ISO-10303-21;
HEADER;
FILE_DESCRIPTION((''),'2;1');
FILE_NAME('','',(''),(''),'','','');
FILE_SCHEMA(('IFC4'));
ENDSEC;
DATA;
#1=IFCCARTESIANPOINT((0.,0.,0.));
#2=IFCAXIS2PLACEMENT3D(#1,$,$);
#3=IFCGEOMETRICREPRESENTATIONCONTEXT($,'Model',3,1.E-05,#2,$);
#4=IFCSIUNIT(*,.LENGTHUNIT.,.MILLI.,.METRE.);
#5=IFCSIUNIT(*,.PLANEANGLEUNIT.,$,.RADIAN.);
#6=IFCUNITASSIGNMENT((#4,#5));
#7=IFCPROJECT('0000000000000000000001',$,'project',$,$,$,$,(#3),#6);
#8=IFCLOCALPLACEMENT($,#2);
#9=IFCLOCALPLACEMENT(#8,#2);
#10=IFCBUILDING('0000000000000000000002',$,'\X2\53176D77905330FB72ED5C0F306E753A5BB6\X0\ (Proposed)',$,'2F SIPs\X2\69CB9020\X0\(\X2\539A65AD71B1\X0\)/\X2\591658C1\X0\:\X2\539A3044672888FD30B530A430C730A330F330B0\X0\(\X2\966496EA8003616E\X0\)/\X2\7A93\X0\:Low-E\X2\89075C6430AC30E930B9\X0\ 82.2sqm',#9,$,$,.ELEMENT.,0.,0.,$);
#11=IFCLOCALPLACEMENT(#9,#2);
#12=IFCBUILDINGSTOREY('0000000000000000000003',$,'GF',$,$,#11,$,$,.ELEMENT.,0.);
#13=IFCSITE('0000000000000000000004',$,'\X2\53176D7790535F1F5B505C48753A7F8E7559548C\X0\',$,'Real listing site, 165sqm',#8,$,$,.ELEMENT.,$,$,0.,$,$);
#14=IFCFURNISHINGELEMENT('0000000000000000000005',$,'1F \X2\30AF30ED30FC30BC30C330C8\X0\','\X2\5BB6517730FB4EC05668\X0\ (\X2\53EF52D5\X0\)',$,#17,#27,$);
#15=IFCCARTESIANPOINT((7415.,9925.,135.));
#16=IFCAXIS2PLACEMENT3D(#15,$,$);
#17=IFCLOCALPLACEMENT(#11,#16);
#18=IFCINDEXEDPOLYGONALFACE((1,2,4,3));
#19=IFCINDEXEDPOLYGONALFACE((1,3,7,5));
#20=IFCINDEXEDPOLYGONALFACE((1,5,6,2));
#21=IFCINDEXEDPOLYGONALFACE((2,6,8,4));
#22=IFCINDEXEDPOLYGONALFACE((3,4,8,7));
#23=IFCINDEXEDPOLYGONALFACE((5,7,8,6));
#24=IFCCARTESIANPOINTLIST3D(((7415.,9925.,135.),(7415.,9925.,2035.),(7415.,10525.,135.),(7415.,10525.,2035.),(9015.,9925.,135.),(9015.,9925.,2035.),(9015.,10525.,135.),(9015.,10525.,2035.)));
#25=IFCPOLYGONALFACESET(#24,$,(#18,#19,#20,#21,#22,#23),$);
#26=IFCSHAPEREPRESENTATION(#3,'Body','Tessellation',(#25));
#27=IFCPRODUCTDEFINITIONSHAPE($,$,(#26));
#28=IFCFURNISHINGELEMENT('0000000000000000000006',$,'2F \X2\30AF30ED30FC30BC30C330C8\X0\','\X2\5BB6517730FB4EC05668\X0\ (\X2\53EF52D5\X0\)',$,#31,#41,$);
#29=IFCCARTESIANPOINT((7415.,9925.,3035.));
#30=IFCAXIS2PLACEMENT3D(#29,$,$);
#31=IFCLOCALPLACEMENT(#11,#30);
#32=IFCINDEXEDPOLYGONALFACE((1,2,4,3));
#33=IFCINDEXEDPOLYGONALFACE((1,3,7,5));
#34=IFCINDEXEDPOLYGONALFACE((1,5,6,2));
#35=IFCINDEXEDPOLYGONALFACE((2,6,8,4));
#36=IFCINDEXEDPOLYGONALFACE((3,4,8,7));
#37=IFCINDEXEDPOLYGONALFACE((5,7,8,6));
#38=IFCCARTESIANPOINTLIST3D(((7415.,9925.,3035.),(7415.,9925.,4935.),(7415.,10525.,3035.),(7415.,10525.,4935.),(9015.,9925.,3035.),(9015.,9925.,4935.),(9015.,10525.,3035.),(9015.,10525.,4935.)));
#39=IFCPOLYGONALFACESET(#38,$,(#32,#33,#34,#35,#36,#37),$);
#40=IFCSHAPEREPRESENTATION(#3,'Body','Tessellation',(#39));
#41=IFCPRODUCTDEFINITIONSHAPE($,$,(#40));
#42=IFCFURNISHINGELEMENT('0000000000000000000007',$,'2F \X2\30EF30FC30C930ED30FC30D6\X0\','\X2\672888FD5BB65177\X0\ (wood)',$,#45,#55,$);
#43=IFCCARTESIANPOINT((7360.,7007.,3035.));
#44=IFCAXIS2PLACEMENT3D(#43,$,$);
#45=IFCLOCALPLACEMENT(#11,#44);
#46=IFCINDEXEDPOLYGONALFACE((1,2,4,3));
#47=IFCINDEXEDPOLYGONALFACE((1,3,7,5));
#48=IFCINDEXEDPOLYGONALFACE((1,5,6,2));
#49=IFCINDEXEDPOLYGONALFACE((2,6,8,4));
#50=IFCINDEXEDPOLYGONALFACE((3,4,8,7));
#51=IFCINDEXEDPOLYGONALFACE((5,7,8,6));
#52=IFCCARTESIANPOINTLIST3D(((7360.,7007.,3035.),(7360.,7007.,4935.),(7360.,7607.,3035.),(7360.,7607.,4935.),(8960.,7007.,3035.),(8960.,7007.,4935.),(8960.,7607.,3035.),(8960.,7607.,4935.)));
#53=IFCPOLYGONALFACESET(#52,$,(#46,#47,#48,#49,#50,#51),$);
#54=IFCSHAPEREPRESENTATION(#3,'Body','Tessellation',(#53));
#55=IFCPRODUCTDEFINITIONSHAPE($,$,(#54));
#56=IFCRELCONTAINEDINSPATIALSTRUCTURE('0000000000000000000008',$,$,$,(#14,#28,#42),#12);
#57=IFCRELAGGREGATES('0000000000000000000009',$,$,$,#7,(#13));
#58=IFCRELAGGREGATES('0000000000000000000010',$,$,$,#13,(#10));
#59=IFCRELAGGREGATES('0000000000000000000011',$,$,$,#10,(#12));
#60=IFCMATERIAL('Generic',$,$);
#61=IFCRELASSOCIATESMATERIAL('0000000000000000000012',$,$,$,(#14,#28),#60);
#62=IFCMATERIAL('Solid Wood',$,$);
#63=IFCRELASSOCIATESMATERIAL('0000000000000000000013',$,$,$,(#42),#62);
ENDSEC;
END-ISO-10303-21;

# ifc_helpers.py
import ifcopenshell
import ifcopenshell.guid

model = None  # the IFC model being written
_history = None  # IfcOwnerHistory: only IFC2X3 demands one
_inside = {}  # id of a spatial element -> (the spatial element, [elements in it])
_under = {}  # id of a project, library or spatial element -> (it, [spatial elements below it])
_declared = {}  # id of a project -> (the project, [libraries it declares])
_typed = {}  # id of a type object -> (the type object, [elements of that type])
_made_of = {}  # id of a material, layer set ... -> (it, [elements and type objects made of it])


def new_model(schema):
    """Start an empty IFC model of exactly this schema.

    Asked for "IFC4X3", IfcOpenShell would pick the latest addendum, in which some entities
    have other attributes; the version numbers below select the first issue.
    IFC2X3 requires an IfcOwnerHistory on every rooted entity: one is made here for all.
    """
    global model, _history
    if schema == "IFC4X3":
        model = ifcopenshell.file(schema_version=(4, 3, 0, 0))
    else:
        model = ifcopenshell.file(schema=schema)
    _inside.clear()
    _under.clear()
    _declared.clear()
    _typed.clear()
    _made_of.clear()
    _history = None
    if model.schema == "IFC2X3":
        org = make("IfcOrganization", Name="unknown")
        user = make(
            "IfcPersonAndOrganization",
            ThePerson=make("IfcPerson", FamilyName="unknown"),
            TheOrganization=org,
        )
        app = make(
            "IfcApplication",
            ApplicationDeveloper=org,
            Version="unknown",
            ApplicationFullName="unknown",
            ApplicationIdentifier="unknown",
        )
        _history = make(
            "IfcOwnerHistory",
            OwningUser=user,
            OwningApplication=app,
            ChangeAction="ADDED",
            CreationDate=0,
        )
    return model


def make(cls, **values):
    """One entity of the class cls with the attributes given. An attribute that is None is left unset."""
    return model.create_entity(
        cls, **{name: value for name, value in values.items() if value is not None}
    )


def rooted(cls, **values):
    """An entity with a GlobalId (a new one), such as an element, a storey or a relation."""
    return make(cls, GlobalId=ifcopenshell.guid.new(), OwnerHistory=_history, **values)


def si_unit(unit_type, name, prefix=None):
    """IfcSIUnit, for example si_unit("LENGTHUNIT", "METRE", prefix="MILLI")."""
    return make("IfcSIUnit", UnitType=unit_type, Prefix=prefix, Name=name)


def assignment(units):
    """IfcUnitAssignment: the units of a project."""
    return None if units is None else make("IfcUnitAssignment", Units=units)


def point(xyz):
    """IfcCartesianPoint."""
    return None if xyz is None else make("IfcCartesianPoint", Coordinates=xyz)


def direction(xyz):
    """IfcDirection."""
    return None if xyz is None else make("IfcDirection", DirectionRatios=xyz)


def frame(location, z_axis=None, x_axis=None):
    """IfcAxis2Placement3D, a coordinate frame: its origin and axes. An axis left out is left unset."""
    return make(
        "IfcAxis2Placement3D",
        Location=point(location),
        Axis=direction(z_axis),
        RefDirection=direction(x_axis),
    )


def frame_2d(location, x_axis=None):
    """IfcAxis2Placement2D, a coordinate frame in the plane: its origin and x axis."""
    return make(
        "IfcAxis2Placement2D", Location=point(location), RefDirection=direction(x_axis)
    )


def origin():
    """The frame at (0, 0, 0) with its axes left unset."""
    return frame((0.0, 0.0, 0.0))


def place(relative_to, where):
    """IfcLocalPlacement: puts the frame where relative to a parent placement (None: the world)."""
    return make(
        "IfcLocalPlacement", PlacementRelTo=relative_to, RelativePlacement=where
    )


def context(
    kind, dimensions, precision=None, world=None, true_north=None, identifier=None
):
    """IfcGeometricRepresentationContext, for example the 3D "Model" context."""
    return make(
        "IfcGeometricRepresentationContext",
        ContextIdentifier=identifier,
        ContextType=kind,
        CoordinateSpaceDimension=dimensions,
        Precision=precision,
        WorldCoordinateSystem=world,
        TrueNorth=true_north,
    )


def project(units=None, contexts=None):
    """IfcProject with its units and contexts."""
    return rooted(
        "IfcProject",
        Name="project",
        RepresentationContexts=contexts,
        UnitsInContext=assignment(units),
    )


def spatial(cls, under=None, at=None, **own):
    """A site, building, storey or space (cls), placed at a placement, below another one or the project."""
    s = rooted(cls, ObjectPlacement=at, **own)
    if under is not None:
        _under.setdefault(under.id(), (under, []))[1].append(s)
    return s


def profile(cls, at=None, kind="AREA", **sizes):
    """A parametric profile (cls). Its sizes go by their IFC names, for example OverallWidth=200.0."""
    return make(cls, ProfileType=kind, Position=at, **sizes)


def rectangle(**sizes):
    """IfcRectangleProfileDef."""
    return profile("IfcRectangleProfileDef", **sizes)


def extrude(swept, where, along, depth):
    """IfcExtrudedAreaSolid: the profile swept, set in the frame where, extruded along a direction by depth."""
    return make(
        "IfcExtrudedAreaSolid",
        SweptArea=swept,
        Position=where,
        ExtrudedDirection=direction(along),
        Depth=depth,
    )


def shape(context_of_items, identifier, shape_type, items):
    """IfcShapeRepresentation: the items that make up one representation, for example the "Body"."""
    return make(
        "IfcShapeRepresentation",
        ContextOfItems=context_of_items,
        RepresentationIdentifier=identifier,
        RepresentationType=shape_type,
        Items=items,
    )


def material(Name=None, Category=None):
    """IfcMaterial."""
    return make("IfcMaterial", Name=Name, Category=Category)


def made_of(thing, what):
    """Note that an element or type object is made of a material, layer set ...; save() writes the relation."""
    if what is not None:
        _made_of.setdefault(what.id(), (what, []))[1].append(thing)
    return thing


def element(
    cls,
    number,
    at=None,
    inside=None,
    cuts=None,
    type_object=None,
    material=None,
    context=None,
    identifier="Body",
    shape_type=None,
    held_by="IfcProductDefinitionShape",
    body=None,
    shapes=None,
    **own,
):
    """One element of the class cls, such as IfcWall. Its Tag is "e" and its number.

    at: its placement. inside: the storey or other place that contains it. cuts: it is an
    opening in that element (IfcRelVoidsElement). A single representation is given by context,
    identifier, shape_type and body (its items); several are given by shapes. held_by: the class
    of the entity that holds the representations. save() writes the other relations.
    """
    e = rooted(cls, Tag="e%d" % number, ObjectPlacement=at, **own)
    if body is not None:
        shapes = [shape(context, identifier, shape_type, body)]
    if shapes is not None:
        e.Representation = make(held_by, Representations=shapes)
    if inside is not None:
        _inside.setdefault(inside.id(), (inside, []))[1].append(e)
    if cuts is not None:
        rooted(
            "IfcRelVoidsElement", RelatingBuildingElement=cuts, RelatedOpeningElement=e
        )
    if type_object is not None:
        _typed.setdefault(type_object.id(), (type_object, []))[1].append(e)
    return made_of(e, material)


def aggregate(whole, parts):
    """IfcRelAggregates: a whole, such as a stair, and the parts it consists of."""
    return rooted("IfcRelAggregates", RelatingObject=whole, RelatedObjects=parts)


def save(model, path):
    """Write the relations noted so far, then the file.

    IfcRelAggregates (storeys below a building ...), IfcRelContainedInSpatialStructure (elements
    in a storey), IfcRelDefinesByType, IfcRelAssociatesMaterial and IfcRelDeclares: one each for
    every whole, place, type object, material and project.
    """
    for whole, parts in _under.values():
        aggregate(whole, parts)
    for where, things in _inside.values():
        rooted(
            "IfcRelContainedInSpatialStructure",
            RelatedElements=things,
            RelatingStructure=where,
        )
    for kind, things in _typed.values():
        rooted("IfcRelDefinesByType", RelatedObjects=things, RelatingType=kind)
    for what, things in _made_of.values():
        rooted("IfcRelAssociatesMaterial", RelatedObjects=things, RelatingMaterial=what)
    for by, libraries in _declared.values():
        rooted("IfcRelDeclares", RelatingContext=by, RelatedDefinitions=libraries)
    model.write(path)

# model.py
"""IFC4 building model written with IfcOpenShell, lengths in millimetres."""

from ifc_helpers import new_model, si_unit, frame, frame_2d, origin, place, context, project, spatial, rectangle, extrude, material, element, save


model = new_model("IFC4")

# Units and contexts
model_context = context("Model", 3, precision=1e-05, world=origin())
ifc_project = project(units=[si_unit("LENGTHUNIT", "METRE", prefix="MILLI"), si_unit("PLANEANGLEUNIT", "RADIAN")], contexts=[model_context])

# Site, building, storey
site_placement = place(None, origin())
site = spatial("IfcSite", under=ifc_project, at=site_placement, Name="北海道弟子屈町美留和", ObjectType="Real listing site, 165sqm", CompositionType="ELEMENT", RefElevation=0.0)
building_placement = place(site_placement, origin())
building = spatial("IfcBuilding", under=site, at=building_placement, Name="北海道・狭小の町家 (Proposed)", ObjectType="2F SIPs構造(厚断熱)/外壁:厚い木製サイディング(除雪考慮)/窓:Low-E複層ガラス 82.2sqm", CompositionType="ELEMENT", ElevationOfRefHeight=0.0, ElevationOfTerrain=0.0)
storey_placement = place(building_placement, origin())
storey = spatial("IfcBuildingStorey", under=building, at=storey_placement, Name="GF", CompositionType="ELEMENT", Elevation=0.0)

# Shared definitions
ifc_material_1 = material(Name="Solid Wood")

# Shared definitions
ifc_material_2 = material(Name="Generic")

# Furnishing elements
furnishing_1_placement = place(storey_placement, frame((7415.0, 9925.0, 135.0)))
element("IfcFurnishingElement", 1, at=furnishing_1_placement, inside=storey, material=ifc_material_2, Name="1F クローゼット", Description="家具・什器 (可動)", context=model_context, shape_type="SweptSolid", body=[
    extrude(rectangle(XDim=1600.0, YDim=600.0, at=frame_2d((800.0, 300.0))), frame((7415.0, 9925.0, 135.0)), (0.0, 0.0, 1.0), 1900.0),
])
furnishing_2_placement = place(storey_placement, frame((7415.0, 9925.0, 3035.0)))
element("IfcFurnishingElement", 2, at=furnishing_2_placement, inside=storey, material=ifc_material_2, Name="2F クローゼット", Description="家具・什器 (可動)", context=model_context, shape_type="SweptSolid", body=[
    extrude(rectangle(XDim=1600.0, YDim=600.0, at=frame_2d((800.0, 300.0))), frame((7415.0, 9925.0, 3035.0)), (0.0, 0.0, 1.0), 1900.0),
])
furnishing_3_placement = place(storey_placement, frame((7360.0, 7007.0, 3035.0)))
element("IfcFurnishingElement", 3, at=furnishing_3_placement, inside=storey, material=ifc_material_1, Name="2F ワードローブ", Description="木製家具 (wood)", context=model_context, shape_type="SweptSolid", body=[
    extrude(rectangle(XDim=1600.0, YDim=600.0, at=frame_2d((800.0, 300.0))), frame((7360.0, 7007.0, 3035.0)), (0.0, 0.0, 1.0), 1900.0),
])

save(model, "model.ifc")
